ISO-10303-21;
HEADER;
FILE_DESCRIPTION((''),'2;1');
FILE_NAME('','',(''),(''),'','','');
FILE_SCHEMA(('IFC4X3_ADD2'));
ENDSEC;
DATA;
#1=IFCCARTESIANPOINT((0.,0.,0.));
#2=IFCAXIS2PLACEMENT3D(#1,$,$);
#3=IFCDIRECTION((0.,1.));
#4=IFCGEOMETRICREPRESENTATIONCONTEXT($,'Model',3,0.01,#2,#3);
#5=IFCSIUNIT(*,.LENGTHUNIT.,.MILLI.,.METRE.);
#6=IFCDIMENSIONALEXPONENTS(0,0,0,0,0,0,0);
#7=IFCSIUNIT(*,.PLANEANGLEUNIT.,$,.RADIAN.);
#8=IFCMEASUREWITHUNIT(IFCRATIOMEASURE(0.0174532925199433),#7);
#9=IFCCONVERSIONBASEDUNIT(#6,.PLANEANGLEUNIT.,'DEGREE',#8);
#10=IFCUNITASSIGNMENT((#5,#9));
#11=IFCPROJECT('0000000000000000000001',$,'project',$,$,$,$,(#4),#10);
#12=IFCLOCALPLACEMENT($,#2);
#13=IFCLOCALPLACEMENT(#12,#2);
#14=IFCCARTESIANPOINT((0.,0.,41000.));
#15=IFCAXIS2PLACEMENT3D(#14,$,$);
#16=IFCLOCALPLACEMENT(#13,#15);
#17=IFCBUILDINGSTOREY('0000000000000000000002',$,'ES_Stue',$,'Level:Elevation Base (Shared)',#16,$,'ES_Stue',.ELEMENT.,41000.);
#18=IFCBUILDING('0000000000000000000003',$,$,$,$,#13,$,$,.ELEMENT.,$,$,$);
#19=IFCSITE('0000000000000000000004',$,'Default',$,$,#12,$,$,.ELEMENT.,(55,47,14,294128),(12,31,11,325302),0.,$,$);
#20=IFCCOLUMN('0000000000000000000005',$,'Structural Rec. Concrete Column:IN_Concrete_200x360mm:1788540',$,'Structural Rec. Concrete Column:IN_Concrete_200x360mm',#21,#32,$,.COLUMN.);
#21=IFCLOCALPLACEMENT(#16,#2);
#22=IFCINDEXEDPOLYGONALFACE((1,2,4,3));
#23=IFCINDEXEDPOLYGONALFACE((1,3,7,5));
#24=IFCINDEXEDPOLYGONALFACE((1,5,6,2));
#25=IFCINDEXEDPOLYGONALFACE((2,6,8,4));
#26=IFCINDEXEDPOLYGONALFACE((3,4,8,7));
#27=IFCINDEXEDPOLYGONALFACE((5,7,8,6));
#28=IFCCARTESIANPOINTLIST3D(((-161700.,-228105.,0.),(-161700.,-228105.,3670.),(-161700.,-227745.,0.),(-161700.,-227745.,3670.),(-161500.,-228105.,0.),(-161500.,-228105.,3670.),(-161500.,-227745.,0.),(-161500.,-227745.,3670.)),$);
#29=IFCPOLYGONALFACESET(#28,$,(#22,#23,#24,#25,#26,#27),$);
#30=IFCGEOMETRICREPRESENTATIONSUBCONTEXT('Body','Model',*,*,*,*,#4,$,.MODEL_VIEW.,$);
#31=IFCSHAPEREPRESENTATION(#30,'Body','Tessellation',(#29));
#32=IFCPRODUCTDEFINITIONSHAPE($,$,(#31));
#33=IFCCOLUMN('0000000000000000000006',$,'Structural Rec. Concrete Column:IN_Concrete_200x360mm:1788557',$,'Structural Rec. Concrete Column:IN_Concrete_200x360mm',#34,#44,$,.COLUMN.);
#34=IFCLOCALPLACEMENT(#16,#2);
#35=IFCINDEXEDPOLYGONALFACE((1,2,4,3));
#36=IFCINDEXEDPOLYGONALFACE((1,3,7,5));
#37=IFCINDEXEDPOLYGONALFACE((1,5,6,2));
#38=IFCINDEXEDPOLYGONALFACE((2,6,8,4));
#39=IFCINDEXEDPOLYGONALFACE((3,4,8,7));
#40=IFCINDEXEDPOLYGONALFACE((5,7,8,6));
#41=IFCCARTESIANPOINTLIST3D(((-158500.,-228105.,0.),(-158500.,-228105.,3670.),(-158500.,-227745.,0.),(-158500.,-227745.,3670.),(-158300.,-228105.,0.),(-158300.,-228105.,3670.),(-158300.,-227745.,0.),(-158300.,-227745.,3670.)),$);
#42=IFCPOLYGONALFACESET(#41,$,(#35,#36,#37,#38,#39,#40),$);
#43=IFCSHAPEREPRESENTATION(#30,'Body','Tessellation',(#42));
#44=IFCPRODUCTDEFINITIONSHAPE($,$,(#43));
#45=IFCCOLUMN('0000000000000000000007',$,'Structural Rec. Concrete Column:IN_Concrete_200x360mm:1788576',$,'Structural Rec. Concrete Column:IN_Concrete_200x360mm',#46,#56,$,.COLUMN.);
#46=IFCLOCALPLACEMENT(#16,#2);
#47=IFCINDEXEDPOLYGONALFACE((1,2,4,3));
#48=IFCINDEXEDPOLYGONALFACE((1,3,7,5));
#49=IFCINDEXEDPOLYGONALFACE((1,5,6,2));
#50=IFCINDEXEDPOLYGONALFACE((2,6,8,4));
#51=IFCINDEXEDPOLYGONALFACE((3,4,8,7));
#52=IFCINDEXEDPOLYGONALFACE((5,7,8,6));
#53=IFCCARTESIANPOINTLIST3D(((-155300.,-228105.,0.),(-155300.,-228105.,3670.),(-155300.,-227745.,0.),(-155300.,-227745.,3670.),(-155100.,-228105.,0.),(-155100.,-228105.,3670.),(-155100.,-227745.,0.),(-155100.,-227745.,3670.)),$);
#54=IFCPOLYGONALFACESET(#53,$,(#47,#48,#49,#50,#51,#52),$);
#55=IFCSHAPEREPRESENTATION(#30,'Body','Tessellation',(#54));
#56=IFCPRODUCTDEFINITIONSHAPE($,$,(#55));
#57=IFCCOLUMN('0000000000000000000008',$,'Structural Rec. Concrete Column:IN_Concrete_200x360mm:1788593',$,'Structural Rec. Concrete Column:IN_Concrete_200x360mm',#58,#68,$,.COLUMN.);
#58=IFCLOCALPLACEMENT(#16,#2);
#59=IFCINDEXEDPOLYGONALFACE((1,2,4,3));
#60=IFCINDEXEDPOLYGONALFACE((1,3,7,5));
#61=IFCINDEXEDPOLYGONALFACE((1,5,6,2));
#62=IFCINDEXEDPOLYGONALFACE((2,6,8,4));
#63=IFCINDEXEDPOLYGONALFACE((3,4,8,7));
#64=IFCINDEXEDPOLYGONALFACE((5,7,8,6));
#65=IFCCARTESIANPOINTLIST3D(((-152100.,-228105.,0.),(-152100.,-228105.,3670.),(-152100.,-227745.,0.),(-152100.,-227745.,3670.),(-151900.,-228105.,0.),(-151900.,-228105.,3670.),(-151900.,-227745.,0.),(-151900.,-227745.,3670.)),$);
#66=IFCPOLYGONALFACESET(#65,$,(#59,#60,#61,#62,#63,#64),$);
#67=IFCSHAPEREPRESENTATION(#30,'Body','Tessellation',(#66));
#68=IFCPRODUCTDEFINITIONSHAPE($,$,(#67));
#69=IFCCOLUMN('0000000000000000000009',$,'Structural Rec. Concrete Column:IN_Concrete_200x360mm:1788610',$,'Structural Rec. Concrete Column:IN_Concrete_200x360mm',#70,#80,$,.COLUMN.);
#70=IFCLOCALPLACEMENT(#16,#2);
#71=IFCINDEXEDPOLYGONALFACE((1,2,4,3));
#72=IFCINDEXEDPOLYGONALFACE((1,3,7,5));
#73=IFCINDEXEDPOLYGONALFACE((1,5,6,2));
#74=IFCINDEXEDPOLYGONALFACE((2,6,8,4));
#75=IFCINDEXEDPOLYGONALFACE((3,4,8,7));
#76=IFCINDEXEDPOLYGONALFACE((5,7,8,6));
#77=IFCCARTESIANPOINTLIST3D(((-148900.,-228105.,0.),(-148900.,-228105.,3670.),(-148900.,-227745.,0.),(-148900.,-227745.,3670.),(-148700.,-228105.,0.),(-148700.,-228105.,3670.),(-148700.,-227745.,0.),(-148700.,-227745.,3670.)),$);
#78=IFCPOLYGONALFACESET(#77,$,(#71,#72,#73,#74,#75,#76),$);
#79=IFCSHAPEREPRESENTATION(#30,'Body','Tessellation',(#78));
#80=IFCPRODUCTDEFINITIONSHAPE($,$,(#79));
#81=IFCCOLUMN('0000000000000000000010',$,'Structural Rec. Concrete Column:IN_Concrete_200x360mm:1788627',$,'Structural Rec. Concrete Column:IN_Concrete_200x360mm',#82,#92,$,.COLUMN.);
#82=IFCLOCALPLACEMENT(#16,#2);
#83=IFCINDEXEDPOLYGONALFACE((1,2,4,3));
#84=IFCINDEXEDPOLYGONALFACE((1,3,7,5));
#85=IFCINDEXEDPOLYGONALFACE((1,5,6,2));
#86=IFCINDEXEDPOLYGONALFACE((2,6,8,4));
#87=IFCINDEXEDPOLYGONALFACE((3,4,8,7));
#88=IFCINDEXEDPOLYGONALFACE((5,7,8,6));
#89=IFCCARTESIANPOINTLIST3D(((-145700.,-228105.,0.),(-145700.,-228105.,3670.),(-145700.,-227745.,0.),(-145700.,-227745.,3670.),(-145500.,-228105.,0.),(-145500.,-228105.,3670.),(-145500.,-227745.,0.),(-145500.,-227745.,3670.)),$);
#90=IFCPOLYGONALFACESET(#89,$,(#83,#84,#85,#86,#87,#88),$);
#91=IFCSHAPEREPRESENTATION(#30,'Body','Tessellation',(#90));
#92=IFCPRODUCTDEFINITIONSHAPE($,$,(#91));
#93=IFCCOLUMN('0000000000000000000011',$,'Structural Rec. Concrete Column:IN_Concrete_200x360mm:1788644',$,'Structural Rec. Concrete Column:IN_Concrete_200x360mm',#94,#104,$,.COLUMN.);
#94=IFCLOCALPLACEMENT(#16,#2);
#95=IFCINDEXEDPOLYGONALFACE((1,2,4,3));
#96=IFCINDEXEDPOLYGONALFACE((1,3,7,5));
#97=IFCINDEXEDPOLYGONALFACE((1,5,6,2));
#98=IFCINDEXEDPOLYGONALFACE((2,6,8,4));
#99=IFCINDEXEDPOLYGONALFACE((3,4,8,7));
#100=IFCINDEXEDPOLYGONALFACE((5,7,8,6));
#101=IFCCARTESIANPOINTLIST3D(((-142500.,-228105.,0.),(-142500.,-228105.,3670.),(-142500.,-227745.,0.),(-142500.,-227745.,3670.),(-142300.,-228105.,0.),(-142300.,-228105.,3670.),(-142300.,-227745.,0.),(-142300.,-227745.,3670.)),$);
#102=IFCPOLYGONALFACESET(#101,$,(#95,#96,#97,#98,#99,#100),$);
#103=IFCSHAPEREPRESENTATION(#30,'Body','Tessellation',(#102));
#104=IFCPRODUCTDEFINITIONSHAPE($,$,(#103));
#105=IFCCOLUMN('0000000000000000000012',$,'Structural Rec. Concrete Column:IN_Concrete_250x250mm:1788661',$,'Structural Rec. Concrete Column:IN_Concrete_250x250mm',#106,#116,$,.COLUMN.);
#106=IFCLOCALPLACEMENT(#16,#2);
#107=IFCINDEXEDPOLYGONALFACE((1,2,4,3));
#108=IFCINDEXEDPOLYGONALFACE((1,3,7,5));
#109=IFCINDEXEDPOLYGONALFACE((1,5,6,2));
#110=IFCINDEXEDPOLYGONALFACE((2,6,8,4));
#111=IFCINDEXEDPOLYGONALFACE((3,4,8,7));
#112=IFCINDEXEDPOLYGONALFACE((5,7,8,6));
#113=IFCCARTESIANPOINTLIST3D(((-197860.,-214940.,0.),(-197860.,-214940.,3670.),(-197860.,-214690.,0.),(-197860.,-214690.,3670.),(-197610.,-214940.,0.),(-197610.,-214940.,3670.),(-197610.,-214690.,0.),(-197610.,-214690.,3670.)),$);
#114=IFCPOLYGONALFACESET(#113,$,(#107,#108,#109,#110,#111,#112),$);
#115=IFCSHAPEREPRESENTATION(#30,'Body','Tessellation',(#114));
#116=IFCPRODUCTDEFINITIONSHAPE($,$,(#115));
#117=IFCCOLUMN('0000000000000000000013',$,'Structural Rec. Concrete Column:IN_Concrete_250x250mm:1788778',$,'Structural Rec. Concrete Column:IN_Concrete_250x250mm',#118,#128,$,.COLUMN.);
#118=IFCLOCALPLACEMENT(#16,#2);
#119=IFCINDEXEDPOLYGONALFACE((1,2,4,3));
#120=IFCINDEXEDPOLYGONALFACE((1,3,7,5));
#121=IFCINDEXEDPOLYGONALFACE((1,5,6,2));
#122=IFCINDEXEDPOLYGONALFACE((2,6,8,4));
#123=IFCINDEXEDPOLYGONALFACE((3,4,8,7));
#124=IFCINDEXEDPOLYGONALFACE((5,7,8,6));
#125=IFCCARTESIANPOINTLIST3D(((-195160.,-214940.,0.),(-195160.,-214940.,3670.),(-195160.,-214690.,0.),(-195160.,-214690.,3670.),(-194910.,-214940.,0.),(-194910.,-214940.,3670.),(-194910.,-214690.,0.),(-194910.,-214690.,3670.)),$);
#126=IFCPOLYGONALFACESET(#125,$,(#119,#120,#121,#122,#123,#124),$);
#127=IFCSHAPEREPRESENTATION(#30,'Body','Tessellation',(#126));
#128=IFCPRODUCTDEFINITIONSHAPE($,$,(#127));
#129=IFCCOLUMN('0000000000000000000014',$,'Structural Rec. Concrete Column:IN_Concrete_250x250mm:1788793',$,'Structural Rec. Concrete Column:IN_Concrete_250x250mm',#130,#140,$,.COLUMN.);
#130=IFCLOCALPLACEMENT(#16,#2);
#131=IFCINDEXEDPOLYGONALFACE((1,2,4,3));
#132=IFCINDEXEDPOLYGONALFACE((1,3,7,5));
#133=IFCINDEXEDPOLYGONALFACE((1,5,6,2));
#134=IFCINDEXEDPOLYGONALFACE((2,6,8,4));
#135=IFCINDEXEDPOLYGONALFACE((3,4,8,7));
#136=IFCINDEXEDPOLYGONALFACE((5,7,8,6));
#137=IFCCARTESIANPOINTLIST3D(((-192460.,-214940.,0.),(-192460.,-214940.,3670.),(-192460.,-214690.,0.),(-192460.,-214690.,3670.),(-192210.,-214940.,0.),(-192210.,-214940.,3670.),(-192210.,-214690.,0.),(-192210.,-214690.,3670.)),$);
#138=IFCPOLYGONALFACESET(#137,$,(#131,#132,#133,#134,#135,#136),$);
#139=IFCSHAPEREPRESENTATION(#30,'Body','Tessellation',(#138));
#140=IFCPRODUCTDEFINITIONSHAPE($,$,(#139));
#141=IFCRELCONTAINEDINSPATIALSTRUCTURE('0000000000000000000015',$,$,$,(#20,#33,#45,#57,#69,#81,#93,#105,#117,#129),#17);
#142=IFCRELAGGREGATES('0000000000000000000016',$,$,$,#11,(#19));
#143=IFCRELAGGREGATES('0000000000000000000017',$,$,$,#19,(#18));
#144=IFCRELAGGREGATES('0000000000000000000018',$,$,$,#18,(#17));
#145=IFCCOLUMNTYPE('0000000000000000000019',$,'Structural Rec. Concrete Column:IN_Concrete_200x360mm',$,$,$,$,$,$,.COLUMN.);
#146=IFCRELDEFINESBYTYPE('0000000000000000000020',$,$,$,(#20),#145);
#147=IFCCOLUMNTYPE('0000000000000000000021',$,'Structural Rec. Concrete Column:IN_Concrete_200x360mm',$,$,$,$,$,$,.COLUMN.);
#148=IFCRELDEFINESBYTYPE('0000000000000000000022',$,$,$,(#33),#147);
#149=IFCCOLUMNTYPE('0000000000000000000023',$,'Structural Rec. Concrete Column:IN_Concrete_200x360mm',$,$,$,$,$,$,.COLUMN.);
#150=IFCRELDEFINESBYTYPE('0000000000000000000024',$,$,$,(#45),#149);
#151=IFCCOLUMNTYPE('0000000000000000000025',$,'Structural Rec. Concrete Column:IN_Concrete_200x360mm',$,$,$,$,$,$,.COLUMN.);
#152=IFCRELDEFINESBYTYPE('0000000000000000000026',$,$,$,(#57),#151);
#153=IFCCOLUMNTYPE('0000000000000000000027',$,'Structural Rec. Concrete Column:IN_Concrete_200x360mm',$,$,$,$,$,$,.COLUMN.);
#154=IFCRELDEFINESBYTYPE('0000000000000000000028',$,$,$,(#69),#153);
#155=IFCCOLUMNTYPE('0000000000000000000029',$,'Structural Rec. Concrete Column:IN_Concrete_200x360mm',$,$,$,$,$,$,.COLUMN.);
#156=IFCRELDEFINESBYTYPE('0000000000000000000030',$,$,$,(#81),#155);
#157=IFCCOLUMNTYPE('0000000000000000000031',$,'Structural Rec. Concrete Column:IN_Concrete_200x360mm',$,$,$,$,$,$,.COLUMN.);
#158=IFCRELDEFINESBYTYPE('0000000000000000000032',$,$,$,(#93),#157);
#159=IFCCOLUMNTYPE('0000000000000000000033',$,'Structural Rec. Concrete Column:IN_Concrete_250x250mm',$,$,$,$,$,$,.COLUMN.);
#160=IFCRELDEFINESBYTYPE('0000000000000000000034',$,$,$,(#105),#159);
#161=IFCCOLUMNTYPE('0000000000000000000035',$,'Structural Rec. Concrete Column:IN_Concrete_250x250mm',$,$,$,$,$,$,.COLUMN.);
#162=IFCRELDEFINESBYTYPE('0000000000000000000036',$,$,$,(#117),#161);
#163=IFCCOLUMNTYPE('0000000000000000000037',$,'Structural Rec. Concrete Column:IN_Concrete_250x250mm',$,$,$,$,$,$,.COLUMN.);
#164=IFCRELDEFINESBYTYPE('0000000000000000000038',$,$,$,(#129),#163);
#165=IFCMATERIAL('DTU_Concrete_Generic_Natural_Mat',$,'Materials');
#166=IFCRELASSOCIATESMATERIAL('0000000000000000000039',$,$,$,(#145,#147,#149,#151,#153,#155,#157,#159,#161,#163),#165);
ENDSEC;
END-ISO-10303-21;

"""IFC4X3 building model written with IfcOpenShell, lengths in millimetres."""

from ifc_helpers import new_model, entity, si_unit, converted_unit, direction, frame, frame_2d, origin, origin_2d_with_axis, place, context, subcontext, project, spatial, rectangle, extrude, source, transform, mapped, material, material_profile, profile_set, type_object, type_shapes, element, save


model = new_model("IFC4X3")

# Units and contexts
model_context = context("Model", 3, precision=0.01, world=origin(), true_north=direction((0.0, 1.0)))
body_context = subcontext(model_context, "Body", "Model", "MODEL_VIEW")
ifc_project = project(units=[si_unit("LENGTHUNIT", "METRE", prefix="MILLI"), converted_unit("PLANEANGLEUNIT", "DEGREE", entity("IfcRatioMeasure", 0.0174532925199433), si_unit("PLANEANGLEUNIT", "RADIAN"), dimensions=[0, 0, 0, 0, 0, 0, 0])], contexts=[model_context])

# Site, building, storey
site_placement = place(None, origin())
site = spatial("IfcSite", under=ifc_project, at=site_placement, Name="Default", CompositionType="ELEMENT", RefLatitude=(55, 47, 14, 294128), RefLongitude=(12, 31, 11, 325302), RefElevation=0.0)
building_placement = place(site_placement, origin())
building = spatial("IfcBuilding", under=site, at=building_placement, CompositionType="ELEMENT")
storey_placement = place(building_placement, frame((0.0, 0.0, 41000.0)))
storey = spatial("IfcBuildingStorey", under=building, at=storey_placement, Name="ES_Stue", ObjectType="Level:Elevation Base (Shared)", LongName="ES_Stue", CompositionType="ELEMENT", Elevation=41000.0)

# Columns
ifc_material = material(Name="DTU_Concrete_Generic_Natural_Mat", Category="Materials")
ifc_material_profile_1 = material_profile(ifc_material, rectangle(XDim=360.0, YDim=200.0, at=frame_2d((0.0, 0.0), x_axis=(1.0, 0.0))), Name="IN_Concrete_200x360mm")
ifc_profile_set_1 = profile_set([ifc_material_profile_1], Name="IN_Concrete_200x360mm")
column_type_1 = type_object("IfcColumnType", Name="Structural Rec. Concrete Column:IN_Concrete_200x360mm", PredefinedType="COLUMN", material=ifc_profile_set_1)
shared_shape_1 = source(origin(), body_context, "Body", "SweptSolid", [
    extrude(rectangle(XDim=360.0, YDim=200.0, at=frame_2d((0.0, 0.0), x_axis=(1.0, 0.0))), frame((-161600.0, -227925.0, 41000.0), z_axis=(0.0, 0.0, 1.0), x_axis=(0.0, -1.0, 0.0)), (0.0, 0.0, 1.0), 3670.0),
])
type_shapes(column_type_1, [shared_shape_1])
column_1_placement = place(storey_placement, frame((0.0, 0.0, -41000.0)))
element("IfcColumn", 1, at=column_1_placement, inside=storey, type_object=column_type_1, Name="Structural Rec. Concrete Column:IN_Concrete_200x360mm:1788540", ObjectType="Structural Rec. Concrete Column:IN_Concrete_200x360mm", PredefinedType="COLUMN", context=body_context, shape_type="MappedRepresentation", body=[
    mapped(shared_shape_1, transform((0.0, 0.0, 0.0), scale=1.0)),
])
column_type_2 = type_object("IfcColumnType", Name="Structural Rec. Concrete Column:IN_Concrete_200x360mm", PredefinedType="COLUMN", material=ifc_profile_set_1)
shared_shape_2 = source(origin(), body_context, "Body", "SweptSolid", [
    extrude(rectangle(XDim=360.0, YDim=200.0, at=frame_2d((0.0, 0.0), x_axis=(1.0, 0.0))), frame((-158400.0, -227925.0, 41000.0), z_axis=(0.0, 0.0, 1.0), x_axis=(0.0, -1.0, 0.0)), (0.0, 0.0, 1.0), 3670.0),
])
type_shapes(column_type_2, [shared_shape_2])
column_2_placement = place(storey_placement, frame((0.0, 0.0, -41000.0)))
element("IfcColumn", 2, at=column_2_placement, inside=storey, type_object=column_type_2, Name="Structural Rec. Concrete Column:IN_Concrete_200x360mm:1788557", ObjectType="Structural Rec. Concrete Column:IN_Concrete_200x360mm", PredefinedType="COLUMN", context=body_context, shape_type="MappedRepresentation", body=[
    mapped(shared_shape_2, transform((0.0, 0.0, 0.0), scale=1.0)),
])
column_type_3 = type_object("IfcColumnType", Name="Structural Rec. Concrete Column:IN_Concrete_200x360mm", PredefinedType="COLUMN", material=ifc_profile_set_1)
shared_shape_3 = source(origin(), body_context, "Body", "SweptSolid", [
    extrude(rectangle(XDim=360.0, YDim=200.0, at=frame_2d((0.0, 0.0), x_axis=(1.0, 0.0))), frame((-155200.0, -227925.0, 41000.0), z_axis=(0.0, 0.0, 1.0), x_axis=(0.0, -1.0, 0.0)), (0.0, 0.0, 1.0), 3670.0),
])
type_shapes(column_type_3, [shared_shape_3])
column_3_placement = place(storey_placement, frame((0.0, 0.0, -41000.0)))
element("IfcColumn", 3, at=column_3_placement, inside=storey, type_object=column_type_3, Name="Structural Rec. Concrete Column:IN_Concrete_200x360mm:1788576", ObjectType="Structural Rec. Concrete Column:IN_Concrete_200x360mm", PredefinedType="COLUMN", context=body_context, shape_type="MappedRepresentation", body=[
    mapped(shared_shape_3, transform((0.0, 0.0, 0.0), scale=1.0)),
])
column_type_4 = type_object("IfcColumnType", Name="Structural Rec. Concrete Column:IN_Concrete_200x360mm", PredefinedType="COLUMN", material=ifc_profile_set_1)
shared_shape_4 = source(origin(), body_context, "Body", "SweptSolid", [
    extrude(rectangle(XDim=360.0, YDim=200.0, at=frame_2d((0.0, 0.0), x_axis=(1.0, 0.0))), frame((-152000.0, -227925.0, 41000.0), z_axis=(0.0, 0.0, 1.0), x_axis=(0.0, -1.0, 0.0)), (0.0, 0.0, 1.0), 3670.0),
])
type_shapes(column_type_4, [shared_shape_4])
column_4_placement = place(storey_placement, frame((0.0, 0.0, -41000.0)))
element("IfcColumn", 4, at=column_4_placement, inside=storey, type_object=column_type_4, Name="Structural Rec. Concrete Column:IN_Concrete_200x360mm:1788593", ObjectType="Structural Rec. Concrete Column:IN_Concrete_200x360mm", PredefinedType="COLUMN", context=body_context, shape_type="MappedRepresentation", body=[
    mapped(shared_shape_4, transform((0.0, 0.0, 0.0), scale=1.0)),
])
column_type_5 = type_object("IfcColumnType", Name="Structural Rec. Concrete Column:IN_Concrete_200x360mm", PredefinedType="COLUMN", material=ifc_profile_set_1)
shared_shape_5 = source(origin(), body_context, "Body", "SweptSolid", [
    extrude(rectangle(XDim=360.0, YDim=200.0, at=frame_2d((0.0, 0.0), x_axis=(1.0, 0.0))), frame((-148800.0, -227925.0, 41000.0), z_axis=(0.0, 0.0, 1.0), x_axis=(0.0, -1.0, 0.0)), (0.0, 0.0, 1.0), 3670.0),
])
type_shapes(column_type_5, [shared_shape_5])
column_5_placement = place(storey_placement, frame((0.0, 0.0, -41000.0)))
element("IfcColumn", 5, at=column_5_placement, inside=storey, type_object=column_type_5, Name="Structural Rec. Concrete Column:IN_Concrete_200x360mm:1788610", ObjectType="Structural Rec. Concrete Column:IN_Concrete_200x360mm", PredefinedType="COLUMN", context=body_context, shape_type="MappedRepresentation", body=[
    mapped(shared_shape_5, transform((0.0, 0.0, 0.0), scale=1.0)),
])
column_type_6 = type_object("IfcColumnType", Name="Structural Rec. Concrete Column:IN_Concrete_200x360mm", PredefinedType="COLUMN", material=ifc_profile_set_1)
shared_shape_6 = source(origin(), body_context, "Body", "SweptSolid", [
    extrude(rectangle(XDim=360.0, YDim=200.0, at=frame_2d((0.0, 0.0), x_axis=(1.0, 0.0))), frame((-145600.0, -227925.0, 41000.0), z_axis=(0.0, 0.0, 1.0), x_axis=(0.0, -1.0, 0.0)), (0.0, 0.0, 1.0), 3670.0),
])
type_shapes(column_type_6, [shared_shape_6])
column_6_placement = place(storey_placement, frame((0.0, 0.0, -41000.0)))
element("IfcColumn", 6, at=column_6_placement, inside=storey, type_object=column_type_6, Name="Structural Rec. Concrete Column:IN_Concrete_200x360mm:1788627", ObjectType="Structural Rec. Concrete Column:IN_Concrete_200x360mm", PredefinedType="COLUMN", context=body_context, shape_type="MappedRepresentation", body=[
    mapped(shared_shape_6, transform((0.0, 0.0, 0.0), scale=1.0)),
])
column_type_7 = type_object("IfcColumnType", Name="Structural Rec. Concrete Column:IN_Concrete_200x360mm", PredefinedType="COLUMN", material=ifc_profile_set_1)
shared_shape_7 = source(origin(), body_context, "Body", "SweptSolid", [
    extrude(rectangle(XDim=360.0, YDim=200.0, at=frame_2d((0.0, 0.0), x_axis=(1.0, 0.0))), frame((-142400.0, -227925.0, 41000.0), z_axis=(0.0, 0.0, 1.0), x_axis=(0.0, -1.0, 0.0)), (0.0, 0.0, 1.0), 3670.0),
])
type_shapes(column_type_7, [shared_shape_7])
column_7_placement = place(storey_placement, frame((0.0, 0.0, -41000.0)))
element("IfcColumn", 7, at=column_7_placement, inside=storey, type_object=column_type_7, Name="Structural Rec. Concrete Column:IN_Concrete_200x360mm:1788644", ObjectType="Structural Rec. Concrete Column:IN_Concrete_200x360mm", PredefinedType="COLUMN", context=body_context, shape_type="MappedRepresentation", body=[
    mapped(shared_shape_7, transform((0.0, 0.0, 0.0), scale=1.0)),
])
ifc_material_profile_2 = material_profile(ifc_material, rectangle(XDim=250.0, YDim=250.0, at=origin_2d_with_axis()), Name="IN_Concrete_250x250mm")
ifc_profile_set_2 = profile_set([ifc_material_profile_2], Name="IN_Concrete_250x250mm")
column_type_8 = type_object("IfcColumnType", Name="Structural Rec. Concrete Column:IN_Concrete_250x250mm", PredefinedType="COLUMN", material=ifc_profile_set_2)
shared_shape_8 = source(origin(), body_context, "Body", "SweptSolid", [
    extrude(rectangle(XDim=250.0, YDim=250.0, at=origin_2d_with_axis()), frame((-197735.0, -214815.0, 41000.0), z_axis=(0.0, 0.0, 1.0), x_axis=(0.0, -1.0, 0.0)), (0.0, 0.0, 1.0), 3670.0),
])
type_shapes(column_type_8, [shared_shape_8])
column_8_placement = place(storey_placement, frame((0.0, 0.0, -41000.0)))
element("IfcColumn", 8, at=column_8_placement, inside=storey, type_object=column_type_8, Name="Structural Rec. Concrete Column:IN_Concrete_250x250mm:1788661", ObjectType="Structural Rec. Concrete Column:IN_Concrete_250x250mm", PredefinedType="COLUMN", context=body_context, shape_type="MappedRepresentation", body=[
    mapped(shared_shape_8, transform((0.0, 0.0, 0.0), scale=1.0)),
])
column_type_9 = type_object("IfcColumnType", Name="Structural Rec. Concrete Column:IN_Concrete_250x250mm", PredefinedType="COLUMN", material=ifc_profile_set_2)
shared_shape_9 = source(origin(), body_context, "Body", "SweptSolid", [
    extrude(rectangle(XDim=250.0, YDim=250.0, at=origin_2d_with_axis()), frame((-195035.0, -214815.0, 41000.0), z_axis=(0.0, 0.0, 1.0), x_axis=(0.0, -1.0, 0.0)), (0.0, 0.0, 1.0), 3670.0),
])
type_shapes(column_type_9, [shared_shape_9])
column_9_placement = place(storey_placement, frame((0.0, 0.0, -41000.0)))
element("IfcColumn", 9, at=column_9_placement, inside=storey, type_object=column_type_9, Name="Structural Rec. Concrete Column:IN_Concrete_250x250mm:1788778", ObjectType="Structural Rec. Concrete Column:IN_Concrete_250x250mm", PredefinedType="COLUMN", context=body_context, shape_type="MappedRepresentation", body=[
    mapped(shared_shape_9, transform((0.0, 0.0, 0.0), scale=1.0)),
])
column_type_10 = type_object("IfcColumnType", Name="Structural Rec. Concrete Column:IN_Concrete_250x250mm", PredefinedType="COLUMN", material=ifc_profile_set_2)
shared_shape_10 = source(origin(), body_context, "Body", "SweptSolid", [
    extrude(rectangle(XDim=250.0, YDim=250.0, at=origin_2d_with_axis()), frame((-192335.0, -214815.0, 41000.0), z_axis=(0.0, 0.0, 1.0), x_axis=(0.0, -1.0, 0.0)), (0.0, 0.0, 1.0), 3670.0),
])
type_shapes(column_type_10, [shared_shape_10])
column_10_placement = place(storey_placement, frame((0.0, 0.0, -41000.0)))
element("IfcColumn", 10, at=column_10_placement, inside=storey, type_object=column_type_10, Name="Structural Rec. Concrete Column:IN_Concrete_250x250mm:1788793", ObjectType="Structural Rec. Concrete Column:IN_Concrete_250x250mm", PredefinedType="COLUMN", context=body_context, shape_type="MappedRepresentation", body=[
    mapped(shared_shape_10, transform((0.0, 0.0, 0.0), scale=1.0)),
])

save(model, "model.ifc")
